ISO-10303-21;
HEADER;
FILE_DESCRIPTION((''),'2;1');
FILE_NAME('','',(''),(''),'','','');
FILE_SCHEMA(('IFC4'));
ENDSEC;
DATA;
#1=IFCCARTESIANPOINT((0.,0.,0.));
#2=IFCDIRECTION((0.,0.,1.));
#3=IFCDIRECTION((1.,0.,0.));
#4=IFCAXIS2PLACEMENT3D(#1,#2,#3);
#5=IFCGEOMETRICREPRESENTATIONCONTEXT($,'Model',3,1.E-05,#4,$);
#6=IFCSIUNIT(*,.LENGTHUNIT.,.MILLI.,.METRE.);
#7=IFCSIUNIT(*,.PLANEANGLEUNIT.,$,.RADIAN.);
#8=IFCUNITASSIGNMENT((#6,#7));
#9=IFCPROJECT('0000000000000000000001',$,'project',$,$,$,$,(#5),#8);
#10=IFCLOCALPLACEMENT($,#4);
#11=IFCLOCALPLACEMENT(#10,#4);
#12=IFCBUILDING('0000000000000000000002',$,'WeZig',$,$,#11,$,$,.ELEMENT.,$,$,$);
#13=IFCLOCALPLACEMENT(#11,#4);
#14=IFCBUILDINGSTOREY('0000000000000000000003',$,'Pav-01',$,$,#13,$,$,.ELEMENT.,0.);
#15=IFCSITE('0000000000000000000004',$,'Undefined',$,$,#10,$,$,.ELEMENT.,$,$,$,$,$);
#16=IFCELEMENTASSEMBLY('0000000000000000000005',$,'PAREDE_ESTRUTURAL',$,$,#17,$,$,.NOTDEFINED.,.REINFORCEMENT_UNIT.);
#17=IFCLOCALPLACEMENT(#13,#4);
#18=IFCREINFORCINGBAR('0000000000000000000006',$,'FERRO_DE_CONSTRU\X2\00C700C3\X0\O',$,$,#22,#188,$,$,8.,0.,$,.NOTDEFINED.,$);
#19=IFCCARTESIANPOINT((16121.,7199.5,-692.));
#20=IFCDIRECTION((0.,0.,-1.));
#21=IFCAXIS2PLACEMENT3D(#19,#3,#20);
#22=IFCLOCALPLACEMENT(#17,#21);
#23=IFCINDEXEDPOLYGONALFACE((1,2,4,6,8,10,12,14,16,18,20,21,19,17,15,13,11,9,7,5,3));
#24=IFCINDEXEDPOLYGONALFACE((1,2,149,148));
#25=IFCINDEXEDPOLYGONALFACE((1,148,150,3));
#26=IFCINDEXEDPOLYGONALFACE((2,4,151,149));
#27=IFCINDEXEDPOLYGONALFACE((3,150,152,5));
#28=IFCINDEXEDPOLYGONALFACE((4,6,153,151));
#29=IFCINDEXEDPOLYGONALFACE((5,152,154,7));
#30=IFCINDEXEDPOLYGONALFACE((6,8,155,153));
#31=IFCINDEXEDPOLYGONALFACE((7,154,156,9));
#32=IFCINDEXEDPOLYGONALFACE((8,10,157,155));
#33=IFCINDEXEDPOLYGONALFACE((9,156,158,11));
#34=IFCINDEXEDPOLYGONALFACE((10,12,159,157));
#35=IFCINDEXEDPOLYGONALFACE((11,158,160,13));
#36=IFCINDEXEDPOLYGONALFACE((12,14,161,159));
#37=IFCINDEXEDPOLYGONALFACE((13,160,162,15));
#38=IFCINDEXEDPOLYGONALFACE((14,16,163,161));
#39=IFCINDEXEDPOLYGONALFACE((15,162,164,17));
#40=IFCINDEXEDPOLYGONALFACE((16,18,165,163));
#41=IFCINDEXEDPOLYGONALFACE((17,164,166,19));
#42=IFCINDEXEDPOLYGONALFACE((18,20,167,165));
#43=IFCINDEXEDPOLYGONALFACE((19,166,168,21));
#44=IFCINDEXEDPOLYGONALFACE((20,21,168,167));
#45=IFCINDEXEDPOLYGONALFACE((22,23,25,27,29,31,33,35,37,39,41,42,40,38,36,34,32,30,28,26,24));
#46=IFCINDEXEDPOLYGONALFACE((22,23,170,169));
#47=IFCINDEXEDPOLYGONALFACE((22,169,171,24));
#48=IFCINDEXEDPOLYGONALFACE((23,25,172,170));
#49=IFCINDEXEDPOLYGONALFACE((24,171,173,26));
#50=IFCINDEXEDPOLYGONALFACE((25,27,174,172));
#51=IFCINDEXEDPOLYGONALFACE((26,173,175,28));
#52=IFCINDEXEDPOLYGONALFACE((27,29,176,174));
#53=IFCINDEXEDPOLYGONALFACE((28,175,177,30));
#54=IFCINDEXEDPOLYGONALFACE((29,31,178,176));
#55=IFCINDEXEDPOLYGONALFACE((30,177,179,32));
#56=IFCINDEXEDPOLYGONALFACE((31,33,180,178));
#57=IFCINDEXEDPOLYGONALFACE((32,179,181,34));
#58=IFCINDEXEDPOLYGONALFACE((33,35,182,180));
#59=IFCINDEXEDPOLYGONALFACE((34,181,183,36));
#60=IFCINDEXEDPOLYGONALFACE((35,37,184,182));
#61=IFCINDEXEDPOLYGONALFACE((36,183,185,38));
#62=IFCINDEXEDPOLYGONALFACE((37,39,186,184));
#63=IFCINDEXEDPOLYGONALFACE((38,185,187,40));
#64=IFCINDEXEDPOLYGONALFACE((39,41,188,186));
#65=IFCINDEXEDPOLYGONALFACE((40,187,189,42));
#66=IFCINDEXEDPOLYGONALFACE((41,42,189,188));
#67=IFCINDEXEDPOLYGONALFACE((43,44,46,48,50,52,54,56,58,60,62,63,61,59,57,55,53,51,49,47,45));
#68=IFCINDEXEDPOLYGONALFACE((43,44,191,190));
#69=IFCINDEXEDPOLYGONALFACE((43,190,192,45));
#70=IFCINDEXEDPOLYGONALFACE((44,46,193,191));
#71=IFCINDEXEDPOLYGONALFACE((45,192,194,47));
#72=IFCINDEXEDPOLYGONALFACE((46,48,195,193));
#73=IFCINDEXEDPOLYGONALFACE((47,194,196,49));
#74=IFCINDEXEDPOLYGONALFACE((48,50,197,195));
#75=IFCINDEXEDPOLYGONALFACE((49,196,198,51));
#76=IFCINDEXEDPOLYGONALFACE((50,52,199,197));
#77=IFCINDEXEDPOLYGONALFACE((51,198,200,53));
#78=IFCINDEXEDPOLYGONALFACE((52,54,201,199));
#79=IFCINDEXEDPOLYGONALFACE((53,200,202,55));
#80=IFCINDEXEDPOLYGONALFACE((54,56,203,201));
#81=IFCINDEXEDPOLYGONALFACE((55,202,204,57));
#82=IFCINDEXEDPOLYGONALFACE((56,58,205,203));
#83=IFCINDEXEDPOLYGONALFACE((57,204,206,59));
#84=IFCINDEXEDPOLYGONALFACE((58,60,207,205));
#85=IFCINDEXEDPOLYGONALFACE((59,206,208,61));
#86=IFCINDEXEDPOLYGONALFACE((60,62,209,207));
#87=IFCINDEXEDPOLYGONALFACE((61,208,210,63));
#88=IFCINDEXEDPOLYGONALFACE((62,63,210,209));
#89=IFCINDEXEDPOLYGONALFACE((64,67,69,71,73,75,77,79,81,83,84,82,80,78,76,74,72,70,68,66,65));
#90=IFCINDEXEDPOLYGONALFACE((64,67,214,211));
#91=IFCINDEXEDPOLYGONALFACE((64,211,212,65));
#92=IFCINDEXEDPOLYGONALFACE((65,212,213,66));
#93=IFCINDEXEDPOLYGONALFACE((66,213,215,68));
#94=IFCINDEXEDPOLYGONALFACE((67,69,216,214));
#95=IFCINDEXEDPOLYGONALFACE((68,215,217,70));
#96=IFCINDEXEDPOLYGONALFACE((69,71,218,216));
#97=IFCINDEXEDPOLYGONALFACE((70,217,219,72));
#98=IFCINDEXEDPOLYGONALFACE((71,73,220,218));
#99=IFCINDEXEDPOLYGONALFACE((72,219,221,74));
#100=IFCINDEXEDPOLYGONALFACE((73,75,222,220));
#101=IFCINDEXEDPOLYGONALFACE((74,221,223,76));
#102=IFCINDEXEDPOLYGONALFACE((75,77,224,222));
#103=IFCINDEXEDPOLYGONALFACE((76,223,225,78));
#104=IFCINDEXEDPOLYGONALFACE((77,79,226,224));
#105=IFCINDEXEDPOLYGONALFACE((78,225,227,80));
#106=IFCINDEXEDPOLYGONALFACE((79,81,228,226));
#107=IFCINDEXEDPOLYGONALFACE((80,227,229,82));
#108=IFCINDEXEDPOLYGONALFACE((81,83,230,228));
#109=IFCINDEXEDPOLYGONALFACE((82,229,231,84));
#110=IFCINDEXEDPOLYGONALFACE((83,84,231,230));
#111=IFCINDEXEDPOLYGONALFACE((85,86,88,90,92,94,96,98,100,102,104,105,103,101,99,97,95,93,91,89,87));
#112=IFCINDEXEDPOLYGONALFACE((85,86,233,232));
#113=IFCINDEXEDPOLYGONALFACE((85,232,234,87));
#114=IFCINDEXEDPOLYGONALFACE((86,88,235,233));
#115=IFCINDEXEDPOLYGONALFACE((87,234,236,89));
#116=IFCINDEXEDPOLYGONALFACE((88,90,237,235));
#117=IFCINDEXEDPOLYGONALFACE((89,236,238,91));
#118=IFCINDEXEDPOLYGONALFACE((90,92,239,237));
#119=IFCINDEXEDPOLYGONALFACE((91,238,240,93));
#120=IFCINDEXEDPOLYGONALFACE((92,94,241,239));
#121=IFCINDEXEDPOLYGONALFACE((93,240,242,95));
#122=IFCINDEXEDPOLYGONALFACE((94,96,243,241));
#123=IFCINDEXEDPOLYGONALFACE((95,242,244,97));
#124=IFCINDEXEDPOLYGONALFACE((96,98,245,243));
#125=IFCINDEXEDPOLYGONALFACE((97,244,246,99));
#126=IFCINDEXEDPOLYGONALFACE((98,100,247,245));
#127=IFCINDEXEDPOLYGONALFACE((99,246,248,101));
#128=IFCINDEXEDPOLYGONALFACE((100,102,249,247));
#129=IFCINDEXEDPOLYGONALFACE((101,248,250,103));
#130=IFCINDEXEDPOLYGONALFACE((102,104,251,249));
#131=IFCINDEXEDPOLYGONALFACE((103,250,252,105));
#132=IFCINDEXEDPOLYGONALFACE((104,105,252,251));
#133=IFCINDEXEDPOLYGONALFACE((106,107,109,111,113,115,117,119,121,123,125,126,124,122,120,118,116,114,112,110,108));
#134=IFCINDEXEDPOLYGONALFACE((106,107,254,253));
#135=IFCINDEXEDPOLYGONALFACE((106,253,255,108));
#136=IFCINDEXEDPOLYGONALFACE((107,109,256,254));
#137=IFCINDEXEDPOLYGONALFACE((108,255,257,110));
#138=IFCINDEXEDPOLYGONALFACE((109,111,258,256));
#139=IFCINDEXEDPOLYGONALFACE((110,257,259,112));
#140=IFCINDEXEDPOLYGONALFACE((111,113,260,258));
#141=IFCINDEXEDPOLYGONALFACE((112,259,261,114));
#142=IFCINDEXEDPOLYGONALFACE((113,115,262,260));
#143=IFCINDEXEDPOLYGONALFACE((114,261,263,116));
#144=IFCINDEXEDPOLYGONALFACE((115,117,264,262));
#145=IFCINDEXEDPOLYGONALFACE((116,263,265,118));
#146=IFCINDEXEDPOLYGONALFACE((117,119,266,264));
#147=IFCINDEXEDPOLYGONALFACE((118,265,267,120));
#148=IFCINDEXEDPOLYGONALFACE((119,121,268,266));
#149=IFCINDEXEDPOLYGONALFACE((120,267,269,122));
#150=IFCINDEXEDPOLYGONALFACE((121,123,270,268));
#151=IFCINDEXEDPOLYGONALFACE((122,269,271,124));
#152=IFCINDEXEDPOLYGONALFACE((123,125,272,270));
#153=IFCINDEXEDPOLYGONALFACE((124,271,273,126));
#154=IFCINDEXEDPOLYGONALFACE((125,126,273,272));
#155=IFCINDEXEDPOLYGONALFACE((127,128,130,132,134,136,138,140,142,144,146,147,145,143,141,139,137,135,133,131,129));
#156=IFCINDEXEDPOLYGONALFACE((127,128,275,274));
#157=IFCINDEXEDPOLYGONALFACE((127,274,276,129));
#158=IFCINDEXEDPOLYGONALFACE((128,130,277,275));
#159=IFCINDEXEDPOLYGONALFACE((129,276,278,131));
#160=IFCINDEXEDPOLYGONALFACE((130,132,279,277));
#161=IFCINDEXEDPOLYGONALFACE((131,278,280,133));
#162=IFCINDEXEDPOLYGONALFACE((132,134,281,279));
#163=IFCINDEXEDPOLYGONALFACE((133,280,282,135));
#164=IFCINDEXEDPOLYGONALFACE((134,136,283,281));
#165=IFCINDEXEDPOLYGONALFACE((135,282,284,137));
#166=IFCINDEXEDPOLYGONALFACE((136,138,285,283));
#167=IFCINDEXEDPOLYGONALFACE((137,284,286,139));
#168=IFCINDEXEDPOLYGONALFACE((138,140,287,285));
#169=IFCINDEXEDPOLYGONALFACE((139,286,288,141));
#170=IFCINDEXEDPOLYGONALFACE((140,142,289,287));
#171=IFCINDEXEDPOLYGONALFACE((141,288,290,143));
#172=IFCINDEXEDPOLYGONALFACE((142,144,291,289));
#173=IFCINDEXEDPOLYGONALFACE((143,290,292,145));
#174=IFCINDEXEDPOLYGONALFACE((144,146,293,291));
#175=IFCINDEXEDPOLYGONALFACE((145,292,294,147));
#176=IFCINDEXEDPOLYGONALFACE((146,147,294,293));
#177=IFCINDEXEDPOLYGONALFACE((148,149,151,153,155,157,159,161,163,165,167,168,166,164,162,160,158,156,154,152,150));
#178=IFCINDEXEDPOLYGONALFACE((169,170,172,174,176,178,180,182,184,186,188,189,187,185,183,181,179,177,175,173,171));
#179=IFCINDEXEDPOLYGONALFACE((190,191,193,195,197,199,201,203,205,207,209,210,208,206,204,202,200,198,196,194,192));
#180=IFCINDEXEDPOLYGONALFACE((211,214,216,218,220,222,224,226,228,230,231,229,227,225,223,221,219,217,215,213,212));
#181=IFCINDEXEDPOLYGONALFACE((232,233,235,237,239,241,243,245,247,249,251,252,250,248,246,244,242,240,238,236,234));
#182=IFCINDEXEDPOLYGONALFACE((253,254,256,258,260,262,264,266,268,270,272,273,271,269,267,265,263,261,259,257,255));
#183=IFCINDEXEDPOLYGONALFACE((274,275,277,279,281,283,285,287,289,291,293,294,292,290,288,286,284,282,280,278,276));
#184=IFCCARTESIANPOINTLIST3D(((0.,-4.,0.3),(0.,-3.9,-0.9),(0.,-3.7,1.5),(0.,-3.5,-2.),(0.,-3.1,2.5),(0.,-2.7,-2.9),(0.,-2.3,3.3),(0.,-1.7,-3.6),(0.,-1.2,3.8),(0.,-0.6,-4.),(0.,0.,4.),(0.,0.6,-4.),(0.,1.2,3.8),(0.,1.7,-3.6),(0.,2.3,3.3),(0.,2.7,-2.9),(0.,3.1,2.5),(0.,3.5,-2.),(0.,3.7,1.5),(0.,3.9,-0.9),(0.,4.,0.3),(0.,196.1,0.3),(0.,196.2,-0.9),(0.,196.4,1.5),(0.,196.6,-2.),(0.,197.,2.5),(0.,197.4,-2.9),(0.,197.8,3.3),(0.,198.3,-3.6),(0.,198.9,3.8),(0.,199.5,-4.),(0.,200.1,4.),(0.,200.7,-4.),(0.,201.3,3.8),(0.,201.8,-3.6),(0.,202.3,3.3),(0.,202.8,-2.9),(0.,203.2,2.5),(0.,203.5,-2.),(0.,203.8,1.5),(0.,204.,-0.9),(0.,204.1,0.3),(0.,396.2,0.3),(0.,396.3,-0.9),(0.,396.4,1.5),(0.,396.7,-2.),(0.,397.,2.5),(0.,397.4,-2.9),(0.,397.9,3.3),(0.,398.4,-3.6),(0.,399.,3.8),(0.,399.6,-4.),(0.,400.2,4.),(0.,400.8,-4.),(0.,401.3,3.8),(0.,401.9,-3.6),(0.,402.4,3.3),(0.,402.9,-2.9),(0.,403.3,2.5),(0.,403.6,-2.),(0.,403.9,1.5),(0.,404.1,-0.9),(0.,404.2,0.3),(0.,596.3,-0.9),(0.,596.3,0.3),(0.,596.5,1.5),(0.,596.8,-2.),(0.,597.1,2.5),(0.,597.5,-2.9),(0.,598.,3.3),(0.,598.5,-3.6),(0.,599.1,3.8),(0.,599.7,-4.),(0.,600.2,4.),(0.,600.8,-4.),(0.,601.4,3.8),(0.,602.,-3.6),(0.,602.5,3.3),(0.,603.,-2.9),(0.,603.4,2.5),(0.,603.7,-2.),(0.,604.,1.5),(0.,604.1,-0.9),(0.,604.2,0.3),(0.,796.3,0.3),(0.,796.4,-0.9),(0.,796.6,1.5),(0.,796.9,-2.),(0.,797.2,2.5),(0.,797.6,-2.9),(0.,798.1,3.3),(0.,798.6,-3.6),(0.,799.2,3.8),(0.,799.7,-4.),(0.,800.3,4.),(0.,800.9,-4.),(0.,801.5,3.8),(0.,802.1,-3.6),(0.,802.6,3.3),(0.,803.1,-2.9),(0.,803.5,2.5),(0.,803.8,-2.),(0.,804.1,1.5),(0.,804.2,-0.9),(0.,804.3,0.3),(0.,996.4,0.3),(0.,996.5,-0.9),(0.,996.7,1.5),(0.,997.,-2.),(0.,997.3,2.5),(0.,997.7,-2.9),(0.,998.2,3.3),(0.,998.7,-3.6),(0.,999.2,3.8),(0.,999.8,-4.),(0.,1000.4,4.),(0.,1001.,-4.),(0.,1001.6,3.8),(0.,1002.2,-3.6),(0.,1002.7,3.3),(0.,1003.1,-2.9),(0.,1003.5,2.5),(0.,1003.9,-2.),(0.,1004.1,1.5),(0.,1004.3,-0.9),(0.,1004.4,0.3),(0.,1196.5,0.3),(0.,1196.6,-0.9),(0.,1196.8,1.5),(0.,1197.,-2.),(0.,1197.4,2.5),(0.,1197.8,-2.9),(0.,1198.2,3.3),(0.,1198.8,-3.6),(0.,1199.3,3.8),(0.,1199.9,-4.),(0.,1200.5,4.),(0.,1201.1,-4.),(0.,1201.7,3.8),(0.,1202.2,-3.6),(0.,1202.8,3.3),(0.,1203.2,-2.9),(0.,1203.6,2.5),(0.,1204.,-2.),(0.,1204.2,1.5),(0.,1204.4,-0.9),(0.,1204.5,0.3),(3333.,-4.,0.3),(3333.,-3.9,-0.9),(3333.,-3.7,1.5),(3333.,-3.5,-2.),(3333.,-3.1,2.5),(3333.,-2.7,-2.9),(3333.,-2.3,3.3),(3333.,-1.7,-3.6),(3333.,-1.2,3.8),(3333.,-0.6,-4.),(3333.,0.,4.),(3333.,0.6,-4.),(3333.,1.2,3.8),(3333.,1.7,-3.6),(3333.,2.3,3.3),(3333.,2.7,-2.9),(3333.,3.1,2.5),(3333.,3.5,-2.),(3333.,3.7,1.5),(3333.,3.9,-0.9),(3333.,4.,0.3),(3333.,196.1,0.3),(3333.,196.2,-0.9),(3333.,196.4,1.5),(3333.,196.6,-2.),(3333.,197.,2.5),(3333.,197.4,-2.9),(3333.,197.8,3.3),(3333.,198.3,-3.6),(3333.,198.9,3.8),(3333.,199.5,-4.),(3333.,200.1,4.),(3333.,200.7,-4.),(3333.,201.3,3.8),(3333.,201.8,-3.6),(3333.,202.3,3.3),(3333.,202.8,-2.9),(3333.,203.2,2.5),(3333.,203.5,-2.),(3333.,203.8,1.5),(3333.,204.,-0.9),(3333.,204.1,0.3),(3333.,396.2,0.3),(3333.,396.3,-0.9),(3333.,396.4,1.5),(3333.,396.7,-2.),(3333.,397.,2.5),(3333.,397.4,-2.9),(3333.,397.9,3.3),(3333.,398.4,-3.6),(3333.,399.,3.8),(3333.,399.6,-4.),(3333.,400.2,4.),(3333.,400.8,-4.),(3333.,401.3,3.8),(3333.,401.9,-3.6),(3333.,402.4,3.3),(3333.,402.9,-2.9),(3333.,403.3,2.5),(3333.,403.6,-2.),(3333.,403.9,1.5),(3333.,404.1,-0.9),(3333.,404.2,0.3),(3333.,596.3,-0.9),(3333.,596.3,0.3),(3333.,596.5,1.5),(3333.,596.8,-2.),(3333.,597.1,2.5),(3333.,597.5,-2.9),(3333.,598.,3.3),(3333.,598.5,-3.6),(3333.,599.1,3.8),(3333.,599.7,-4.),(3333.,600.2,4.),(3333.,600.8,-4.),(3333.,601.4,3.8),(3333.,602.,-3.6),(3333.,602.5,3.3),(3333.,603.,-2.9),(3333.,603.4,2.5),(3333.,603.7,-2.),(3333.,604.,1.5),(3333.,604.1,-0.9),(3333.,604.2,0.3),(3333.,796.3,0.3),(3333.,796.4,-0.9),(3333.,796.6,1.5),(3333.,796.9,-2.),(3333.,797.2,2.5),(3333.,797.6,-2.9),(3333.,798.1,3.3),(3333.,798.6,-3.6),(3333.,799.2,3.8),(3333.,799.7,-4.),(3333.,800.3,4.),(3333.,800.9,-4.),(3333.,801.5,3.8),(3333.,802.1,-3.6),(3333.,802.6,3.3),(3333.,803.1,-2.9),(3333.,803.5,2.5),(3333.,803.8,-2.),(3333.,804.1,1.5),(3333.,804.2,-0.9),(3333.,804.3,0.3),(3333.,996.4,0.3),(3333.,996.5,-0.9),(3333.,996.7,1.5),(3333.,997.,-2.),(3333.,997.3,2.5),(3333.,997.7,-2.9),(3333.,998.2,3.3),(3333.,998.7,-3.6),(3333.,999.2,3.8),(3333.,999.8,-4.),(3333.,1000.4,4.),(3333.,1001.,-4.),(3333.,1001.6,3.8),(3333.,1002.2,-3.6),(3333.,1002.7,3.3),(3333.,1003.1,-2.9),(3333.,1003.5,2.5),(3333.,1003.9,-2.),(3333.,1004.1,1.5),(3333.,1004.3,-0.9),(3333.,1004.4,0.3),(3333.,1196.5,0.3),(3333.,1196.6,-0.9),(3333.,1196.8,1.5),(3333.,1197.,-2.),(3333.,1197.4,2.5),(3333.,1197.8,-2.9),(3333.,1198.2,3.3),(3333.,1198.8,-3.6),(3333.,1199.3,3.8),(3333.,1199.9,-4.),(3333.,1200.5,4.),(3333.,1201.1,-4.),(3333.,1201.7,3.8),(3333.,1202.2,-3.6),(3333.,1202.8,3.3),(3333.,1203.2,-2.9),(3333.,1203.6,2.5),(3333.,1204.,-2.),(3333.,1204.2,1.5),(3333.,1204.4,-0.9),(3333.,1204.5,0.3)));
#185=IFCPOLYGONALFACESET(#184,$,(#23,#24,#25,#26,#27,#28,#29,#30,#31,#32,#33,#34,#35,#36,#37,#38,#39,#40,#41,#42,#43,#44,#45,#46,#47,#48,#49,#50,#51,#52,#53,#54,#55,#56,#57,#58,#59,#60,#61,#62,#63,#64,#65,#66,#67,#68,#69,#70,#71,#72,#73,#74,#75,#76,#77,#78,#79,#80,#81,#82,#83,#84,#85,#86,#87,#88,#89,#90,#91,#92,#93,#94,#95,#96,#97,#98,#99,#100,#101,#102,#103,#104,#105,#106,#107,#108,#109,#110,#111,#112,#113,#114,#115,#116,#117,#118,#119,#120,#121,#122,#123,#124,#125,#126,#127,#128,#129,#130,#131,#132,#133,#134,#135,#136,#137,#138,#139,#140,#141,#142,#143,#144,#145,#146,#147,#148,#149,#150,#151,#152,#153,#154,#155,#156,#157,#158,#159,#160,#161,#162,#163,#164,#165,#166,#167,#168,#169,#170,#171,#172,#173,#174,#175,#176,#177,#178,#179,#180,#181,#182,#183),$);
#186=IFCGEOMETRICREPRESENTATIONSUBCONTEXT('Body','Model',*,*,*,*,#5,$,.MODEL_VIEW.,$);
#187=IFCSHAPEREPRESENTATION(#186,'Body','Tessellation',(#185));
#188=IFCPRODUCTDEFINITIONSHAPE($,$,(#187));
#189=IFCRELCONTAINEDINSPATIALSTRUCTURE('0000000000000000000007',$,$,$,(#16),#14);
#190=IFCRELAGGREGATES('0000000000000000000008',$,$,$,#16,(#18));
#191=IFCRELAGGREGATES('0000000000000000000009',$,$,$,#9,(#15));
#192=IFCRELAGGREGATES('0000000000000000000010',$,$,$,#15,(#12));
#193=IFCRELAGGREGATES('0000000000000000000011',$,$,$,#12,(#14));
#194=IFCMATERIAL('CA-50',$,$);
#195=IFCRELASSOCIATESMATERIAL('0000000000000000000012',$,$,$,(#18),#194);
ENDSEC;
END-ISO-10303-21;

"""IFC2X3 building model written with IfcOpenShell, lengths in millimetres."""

from ifc_helpers import new_model, entity, si_unit, frame, origin_with_axes, place, context, subcontext, project, spatial, source, transform, mapped, material, element, aggregate, save


model = new_model("IFC2X3")

# Units and contexts
model_context = context("Model", 3, precision=1e-05, world=origin_with_axes())
body_context = subcontext(model_context, "Body", "Model", "MODEL_VIEW")
ifc_project = project(units=[si_unit("LENGTHUNIT", "METRE", prefix="MILLI"), si_unit("PLANEANGLEUNIT", "RADIAN")], contexts=[model_context])

# Site, building, storey
site_placement = place(None, origin_with_axes())
site = spatial("IfcSite", under=ifc_project, at=site_placement, Name="Undefined", CompositionType="ELEMENT")
building_placement = place(site_placement, origin_with_axes())
building = spatial("IfcBuilding", under=site, at=building_placement, Name="WeZig", CompositionType="ELEMENT")
storey_placement = place(building_placement, origin_with_axes())
storey = spatial("IfcBuildingStorey", under=building, at=storey_placement, Name="Pav-01", CompositionType="ELEMENT", Elevation=0.0)

# Element assembly
assembly_1_placement = place(storey_placement, origin_with_axes())
assembly_1 = element("IfcElementAssembly", 1, at=assembly_1_placement, inside=storey, Name="PAREDE_ESTRUTURAL", AssemblyPlace="NOTDEFINED", PredefinedType="REINFORCEMENT_UNIT")

# Shared definitions
ifc_material_1 = material(Name="CA-50")

# Reinforcing bar
shared_shape_1 = source(origin_with_axes(), body_context, "Body", "AdvancedSweptSolid", [
    entity("IfcSweptDiskSolid", entity("IfcTrimmedCurve", entity("IfcLine", entity("IfcCartesianPoint", [0.0, 0.0, 0.0]), entity("IfcVector", entity("IfcDirection", [1.0, 0.0, 0.0]), 1.0)), [entity("IfcParameterValue", 0.0)], [entity("IfcParameterValue", 3333.0)], True, "PARAMETER"), 4.0, None, 0.0, 3333.0),
])
shared_shape_2 = source(origin_with_axes(), body_context, "Body", "AdvancedSweptSolid", [
    entity("IfcSweptDiskSolid", entity("IfcTrimmedCurve", entity("IfcLine", entity("IfcCartesianPoint", [0.0, 0.0, 0.0]), entity("IfcVector", entity("IfcDirection", [1.0, 0.0, 0.0]), 1.0)), [entity("IfcParameterValue", 0.0)], [entity("IfcParameterValue", 3333.0)], True, "PARAMETER"), 4.0, None, 0.0, 3333.0),
])
shared_shape_3 = source(origin_with_axes(), body_context, "Body", "AdvancedSweptSolid", [
    entity("IfcSweptDiskSolid", entity("IfcTrimmedCurve", entity("IfcLine", entity("IfcCartesianPoint", [0.0, 0.0, 0.0]), entity("IfcVector", entity("IfcDirection", [1.0, 0.0, 0.0]), 1.0)), [entity("IfcParameterValue", 0.0)], [entity("IfcParameterValue", 3333.0)], True, "PARAMETER"), 4.0, None, 0.0, 3333.0),
])
shared_shape_4 = source(origin_with_axes(), body_context, "Body", "AdvancedSweptSolid", [
    entity("IfcSweptDiskSolid", entity("IfcTrimmedCurve", entity("IfcLine", entity("IfcCartesianPoint", [0.0, 0.0, 0.0]), entity("IfcVector", entity("IfcDirection", [1.0, 0.0, 0.0]), 1.0)), [entity("IfcParameterValue", 0.0)], [entity("IfcParameterValue", 3333.0)], True, "PARAMETER"), 4.0, None, 0.0, 3333.0),
])
shared_shape_5 = source(origin_with_axes(), body_context, "Body", "AdvancedSweptSolid", [
    entity("IfcSweptDiskSolid", entity("IfcTrimmedCurve", entity("IfcLine", entity("IfcCartesianPoint", [0.0, 0.0, 0.0]), entity("IfcVector", entity("IfcDirection", [1.0, 0.0, 0.0]), 1.0)), [entity("IfcParameterValue", 0.0)], [entity("IfcParameterValue", 3333.0)], True, "PARAMETER"), 4.0, None, 0.0, 3333.0),
])
shared_shape_6 = source(origin_with_axes(), body_context, "Body", "AdvancedSweptSolid", [
    entity("IfcSweptDiskSolid", entity("IfcTrimmedCurve", entity("IfcLine", entity("IfcCartesianPoint", [0.0, 0.0, 0.0]), entity("IfcVector", entity("IfcDirection", [1.0, 0.0, 0.0]), 1.0)), [entity("IfcParameterValue", 0.0)], [entity("IfcParameterValue", 3333.0)], True, "PARAMETER"), 4.0, None, 0.0, 3333.0),
])
shared_shape_7 = source(origin_with_axes(), body_context, "Body", "AdvancedSweptSolid", [
    entity("IfcSweptDiskSolid", entity("IfcTrimmedCurve", entity("IfcLine", entity("IfcCartesianPoint", [0.0, 0.0, 0.0]), entity("IfcVector", entity("IfcDirection", [1.0, 0.0, 0.0]), 1.0)), [entity("IfcParameterValue", 0.0)], [entity("IfcParameterValue", 3333.0)], True, "PARAMETER"), 4.0, None, 0.0, 3333.0),
])
reinforcing_bar_1_placement = place(assembly_1_placement, frame((16121.0, 7199.5, -692.0), z_axis=(1.0, 0.0, 0.0), x_axis=(0.0, 0.0, -1.0)))
reinforcing_bar_1 = element("IfcReinforcingBar", 2, at=reinforcing_bar_1_placement, material=ifc_material_1, Name="FERRO_DE_CONSTRUÇÃO", BarRole="NOTDEFINED", CrossSectionArea=0.0, NominalDiameter=8.0, context=body_context, shape_type="MappedRepresentation", body=[
    mapped(shared_shape_1, transform((0.0, 0.0, 0.0))),
    mapped(shared_shape_2, transform((0.0, 200.1, 0.0))),
    mapped(shared_shape_3, transform((0.0, 400.2, 0.0))),
    mapped(shared_shape_4, transform((0.0, 600.2, 0.0))),
    mapped(shared_shape_5, transform((0.0, 800.3, 0.0))),
    mapped(shared_shape_6, transform((0.0, 1000.4, 0.0))),
    mapped(shared_shape_7, transform((0.0, 1200.5, 0.0))),
])
aggregate(assembly_1, [reinforcing_bar_1])

save(model, "model.ifc")
